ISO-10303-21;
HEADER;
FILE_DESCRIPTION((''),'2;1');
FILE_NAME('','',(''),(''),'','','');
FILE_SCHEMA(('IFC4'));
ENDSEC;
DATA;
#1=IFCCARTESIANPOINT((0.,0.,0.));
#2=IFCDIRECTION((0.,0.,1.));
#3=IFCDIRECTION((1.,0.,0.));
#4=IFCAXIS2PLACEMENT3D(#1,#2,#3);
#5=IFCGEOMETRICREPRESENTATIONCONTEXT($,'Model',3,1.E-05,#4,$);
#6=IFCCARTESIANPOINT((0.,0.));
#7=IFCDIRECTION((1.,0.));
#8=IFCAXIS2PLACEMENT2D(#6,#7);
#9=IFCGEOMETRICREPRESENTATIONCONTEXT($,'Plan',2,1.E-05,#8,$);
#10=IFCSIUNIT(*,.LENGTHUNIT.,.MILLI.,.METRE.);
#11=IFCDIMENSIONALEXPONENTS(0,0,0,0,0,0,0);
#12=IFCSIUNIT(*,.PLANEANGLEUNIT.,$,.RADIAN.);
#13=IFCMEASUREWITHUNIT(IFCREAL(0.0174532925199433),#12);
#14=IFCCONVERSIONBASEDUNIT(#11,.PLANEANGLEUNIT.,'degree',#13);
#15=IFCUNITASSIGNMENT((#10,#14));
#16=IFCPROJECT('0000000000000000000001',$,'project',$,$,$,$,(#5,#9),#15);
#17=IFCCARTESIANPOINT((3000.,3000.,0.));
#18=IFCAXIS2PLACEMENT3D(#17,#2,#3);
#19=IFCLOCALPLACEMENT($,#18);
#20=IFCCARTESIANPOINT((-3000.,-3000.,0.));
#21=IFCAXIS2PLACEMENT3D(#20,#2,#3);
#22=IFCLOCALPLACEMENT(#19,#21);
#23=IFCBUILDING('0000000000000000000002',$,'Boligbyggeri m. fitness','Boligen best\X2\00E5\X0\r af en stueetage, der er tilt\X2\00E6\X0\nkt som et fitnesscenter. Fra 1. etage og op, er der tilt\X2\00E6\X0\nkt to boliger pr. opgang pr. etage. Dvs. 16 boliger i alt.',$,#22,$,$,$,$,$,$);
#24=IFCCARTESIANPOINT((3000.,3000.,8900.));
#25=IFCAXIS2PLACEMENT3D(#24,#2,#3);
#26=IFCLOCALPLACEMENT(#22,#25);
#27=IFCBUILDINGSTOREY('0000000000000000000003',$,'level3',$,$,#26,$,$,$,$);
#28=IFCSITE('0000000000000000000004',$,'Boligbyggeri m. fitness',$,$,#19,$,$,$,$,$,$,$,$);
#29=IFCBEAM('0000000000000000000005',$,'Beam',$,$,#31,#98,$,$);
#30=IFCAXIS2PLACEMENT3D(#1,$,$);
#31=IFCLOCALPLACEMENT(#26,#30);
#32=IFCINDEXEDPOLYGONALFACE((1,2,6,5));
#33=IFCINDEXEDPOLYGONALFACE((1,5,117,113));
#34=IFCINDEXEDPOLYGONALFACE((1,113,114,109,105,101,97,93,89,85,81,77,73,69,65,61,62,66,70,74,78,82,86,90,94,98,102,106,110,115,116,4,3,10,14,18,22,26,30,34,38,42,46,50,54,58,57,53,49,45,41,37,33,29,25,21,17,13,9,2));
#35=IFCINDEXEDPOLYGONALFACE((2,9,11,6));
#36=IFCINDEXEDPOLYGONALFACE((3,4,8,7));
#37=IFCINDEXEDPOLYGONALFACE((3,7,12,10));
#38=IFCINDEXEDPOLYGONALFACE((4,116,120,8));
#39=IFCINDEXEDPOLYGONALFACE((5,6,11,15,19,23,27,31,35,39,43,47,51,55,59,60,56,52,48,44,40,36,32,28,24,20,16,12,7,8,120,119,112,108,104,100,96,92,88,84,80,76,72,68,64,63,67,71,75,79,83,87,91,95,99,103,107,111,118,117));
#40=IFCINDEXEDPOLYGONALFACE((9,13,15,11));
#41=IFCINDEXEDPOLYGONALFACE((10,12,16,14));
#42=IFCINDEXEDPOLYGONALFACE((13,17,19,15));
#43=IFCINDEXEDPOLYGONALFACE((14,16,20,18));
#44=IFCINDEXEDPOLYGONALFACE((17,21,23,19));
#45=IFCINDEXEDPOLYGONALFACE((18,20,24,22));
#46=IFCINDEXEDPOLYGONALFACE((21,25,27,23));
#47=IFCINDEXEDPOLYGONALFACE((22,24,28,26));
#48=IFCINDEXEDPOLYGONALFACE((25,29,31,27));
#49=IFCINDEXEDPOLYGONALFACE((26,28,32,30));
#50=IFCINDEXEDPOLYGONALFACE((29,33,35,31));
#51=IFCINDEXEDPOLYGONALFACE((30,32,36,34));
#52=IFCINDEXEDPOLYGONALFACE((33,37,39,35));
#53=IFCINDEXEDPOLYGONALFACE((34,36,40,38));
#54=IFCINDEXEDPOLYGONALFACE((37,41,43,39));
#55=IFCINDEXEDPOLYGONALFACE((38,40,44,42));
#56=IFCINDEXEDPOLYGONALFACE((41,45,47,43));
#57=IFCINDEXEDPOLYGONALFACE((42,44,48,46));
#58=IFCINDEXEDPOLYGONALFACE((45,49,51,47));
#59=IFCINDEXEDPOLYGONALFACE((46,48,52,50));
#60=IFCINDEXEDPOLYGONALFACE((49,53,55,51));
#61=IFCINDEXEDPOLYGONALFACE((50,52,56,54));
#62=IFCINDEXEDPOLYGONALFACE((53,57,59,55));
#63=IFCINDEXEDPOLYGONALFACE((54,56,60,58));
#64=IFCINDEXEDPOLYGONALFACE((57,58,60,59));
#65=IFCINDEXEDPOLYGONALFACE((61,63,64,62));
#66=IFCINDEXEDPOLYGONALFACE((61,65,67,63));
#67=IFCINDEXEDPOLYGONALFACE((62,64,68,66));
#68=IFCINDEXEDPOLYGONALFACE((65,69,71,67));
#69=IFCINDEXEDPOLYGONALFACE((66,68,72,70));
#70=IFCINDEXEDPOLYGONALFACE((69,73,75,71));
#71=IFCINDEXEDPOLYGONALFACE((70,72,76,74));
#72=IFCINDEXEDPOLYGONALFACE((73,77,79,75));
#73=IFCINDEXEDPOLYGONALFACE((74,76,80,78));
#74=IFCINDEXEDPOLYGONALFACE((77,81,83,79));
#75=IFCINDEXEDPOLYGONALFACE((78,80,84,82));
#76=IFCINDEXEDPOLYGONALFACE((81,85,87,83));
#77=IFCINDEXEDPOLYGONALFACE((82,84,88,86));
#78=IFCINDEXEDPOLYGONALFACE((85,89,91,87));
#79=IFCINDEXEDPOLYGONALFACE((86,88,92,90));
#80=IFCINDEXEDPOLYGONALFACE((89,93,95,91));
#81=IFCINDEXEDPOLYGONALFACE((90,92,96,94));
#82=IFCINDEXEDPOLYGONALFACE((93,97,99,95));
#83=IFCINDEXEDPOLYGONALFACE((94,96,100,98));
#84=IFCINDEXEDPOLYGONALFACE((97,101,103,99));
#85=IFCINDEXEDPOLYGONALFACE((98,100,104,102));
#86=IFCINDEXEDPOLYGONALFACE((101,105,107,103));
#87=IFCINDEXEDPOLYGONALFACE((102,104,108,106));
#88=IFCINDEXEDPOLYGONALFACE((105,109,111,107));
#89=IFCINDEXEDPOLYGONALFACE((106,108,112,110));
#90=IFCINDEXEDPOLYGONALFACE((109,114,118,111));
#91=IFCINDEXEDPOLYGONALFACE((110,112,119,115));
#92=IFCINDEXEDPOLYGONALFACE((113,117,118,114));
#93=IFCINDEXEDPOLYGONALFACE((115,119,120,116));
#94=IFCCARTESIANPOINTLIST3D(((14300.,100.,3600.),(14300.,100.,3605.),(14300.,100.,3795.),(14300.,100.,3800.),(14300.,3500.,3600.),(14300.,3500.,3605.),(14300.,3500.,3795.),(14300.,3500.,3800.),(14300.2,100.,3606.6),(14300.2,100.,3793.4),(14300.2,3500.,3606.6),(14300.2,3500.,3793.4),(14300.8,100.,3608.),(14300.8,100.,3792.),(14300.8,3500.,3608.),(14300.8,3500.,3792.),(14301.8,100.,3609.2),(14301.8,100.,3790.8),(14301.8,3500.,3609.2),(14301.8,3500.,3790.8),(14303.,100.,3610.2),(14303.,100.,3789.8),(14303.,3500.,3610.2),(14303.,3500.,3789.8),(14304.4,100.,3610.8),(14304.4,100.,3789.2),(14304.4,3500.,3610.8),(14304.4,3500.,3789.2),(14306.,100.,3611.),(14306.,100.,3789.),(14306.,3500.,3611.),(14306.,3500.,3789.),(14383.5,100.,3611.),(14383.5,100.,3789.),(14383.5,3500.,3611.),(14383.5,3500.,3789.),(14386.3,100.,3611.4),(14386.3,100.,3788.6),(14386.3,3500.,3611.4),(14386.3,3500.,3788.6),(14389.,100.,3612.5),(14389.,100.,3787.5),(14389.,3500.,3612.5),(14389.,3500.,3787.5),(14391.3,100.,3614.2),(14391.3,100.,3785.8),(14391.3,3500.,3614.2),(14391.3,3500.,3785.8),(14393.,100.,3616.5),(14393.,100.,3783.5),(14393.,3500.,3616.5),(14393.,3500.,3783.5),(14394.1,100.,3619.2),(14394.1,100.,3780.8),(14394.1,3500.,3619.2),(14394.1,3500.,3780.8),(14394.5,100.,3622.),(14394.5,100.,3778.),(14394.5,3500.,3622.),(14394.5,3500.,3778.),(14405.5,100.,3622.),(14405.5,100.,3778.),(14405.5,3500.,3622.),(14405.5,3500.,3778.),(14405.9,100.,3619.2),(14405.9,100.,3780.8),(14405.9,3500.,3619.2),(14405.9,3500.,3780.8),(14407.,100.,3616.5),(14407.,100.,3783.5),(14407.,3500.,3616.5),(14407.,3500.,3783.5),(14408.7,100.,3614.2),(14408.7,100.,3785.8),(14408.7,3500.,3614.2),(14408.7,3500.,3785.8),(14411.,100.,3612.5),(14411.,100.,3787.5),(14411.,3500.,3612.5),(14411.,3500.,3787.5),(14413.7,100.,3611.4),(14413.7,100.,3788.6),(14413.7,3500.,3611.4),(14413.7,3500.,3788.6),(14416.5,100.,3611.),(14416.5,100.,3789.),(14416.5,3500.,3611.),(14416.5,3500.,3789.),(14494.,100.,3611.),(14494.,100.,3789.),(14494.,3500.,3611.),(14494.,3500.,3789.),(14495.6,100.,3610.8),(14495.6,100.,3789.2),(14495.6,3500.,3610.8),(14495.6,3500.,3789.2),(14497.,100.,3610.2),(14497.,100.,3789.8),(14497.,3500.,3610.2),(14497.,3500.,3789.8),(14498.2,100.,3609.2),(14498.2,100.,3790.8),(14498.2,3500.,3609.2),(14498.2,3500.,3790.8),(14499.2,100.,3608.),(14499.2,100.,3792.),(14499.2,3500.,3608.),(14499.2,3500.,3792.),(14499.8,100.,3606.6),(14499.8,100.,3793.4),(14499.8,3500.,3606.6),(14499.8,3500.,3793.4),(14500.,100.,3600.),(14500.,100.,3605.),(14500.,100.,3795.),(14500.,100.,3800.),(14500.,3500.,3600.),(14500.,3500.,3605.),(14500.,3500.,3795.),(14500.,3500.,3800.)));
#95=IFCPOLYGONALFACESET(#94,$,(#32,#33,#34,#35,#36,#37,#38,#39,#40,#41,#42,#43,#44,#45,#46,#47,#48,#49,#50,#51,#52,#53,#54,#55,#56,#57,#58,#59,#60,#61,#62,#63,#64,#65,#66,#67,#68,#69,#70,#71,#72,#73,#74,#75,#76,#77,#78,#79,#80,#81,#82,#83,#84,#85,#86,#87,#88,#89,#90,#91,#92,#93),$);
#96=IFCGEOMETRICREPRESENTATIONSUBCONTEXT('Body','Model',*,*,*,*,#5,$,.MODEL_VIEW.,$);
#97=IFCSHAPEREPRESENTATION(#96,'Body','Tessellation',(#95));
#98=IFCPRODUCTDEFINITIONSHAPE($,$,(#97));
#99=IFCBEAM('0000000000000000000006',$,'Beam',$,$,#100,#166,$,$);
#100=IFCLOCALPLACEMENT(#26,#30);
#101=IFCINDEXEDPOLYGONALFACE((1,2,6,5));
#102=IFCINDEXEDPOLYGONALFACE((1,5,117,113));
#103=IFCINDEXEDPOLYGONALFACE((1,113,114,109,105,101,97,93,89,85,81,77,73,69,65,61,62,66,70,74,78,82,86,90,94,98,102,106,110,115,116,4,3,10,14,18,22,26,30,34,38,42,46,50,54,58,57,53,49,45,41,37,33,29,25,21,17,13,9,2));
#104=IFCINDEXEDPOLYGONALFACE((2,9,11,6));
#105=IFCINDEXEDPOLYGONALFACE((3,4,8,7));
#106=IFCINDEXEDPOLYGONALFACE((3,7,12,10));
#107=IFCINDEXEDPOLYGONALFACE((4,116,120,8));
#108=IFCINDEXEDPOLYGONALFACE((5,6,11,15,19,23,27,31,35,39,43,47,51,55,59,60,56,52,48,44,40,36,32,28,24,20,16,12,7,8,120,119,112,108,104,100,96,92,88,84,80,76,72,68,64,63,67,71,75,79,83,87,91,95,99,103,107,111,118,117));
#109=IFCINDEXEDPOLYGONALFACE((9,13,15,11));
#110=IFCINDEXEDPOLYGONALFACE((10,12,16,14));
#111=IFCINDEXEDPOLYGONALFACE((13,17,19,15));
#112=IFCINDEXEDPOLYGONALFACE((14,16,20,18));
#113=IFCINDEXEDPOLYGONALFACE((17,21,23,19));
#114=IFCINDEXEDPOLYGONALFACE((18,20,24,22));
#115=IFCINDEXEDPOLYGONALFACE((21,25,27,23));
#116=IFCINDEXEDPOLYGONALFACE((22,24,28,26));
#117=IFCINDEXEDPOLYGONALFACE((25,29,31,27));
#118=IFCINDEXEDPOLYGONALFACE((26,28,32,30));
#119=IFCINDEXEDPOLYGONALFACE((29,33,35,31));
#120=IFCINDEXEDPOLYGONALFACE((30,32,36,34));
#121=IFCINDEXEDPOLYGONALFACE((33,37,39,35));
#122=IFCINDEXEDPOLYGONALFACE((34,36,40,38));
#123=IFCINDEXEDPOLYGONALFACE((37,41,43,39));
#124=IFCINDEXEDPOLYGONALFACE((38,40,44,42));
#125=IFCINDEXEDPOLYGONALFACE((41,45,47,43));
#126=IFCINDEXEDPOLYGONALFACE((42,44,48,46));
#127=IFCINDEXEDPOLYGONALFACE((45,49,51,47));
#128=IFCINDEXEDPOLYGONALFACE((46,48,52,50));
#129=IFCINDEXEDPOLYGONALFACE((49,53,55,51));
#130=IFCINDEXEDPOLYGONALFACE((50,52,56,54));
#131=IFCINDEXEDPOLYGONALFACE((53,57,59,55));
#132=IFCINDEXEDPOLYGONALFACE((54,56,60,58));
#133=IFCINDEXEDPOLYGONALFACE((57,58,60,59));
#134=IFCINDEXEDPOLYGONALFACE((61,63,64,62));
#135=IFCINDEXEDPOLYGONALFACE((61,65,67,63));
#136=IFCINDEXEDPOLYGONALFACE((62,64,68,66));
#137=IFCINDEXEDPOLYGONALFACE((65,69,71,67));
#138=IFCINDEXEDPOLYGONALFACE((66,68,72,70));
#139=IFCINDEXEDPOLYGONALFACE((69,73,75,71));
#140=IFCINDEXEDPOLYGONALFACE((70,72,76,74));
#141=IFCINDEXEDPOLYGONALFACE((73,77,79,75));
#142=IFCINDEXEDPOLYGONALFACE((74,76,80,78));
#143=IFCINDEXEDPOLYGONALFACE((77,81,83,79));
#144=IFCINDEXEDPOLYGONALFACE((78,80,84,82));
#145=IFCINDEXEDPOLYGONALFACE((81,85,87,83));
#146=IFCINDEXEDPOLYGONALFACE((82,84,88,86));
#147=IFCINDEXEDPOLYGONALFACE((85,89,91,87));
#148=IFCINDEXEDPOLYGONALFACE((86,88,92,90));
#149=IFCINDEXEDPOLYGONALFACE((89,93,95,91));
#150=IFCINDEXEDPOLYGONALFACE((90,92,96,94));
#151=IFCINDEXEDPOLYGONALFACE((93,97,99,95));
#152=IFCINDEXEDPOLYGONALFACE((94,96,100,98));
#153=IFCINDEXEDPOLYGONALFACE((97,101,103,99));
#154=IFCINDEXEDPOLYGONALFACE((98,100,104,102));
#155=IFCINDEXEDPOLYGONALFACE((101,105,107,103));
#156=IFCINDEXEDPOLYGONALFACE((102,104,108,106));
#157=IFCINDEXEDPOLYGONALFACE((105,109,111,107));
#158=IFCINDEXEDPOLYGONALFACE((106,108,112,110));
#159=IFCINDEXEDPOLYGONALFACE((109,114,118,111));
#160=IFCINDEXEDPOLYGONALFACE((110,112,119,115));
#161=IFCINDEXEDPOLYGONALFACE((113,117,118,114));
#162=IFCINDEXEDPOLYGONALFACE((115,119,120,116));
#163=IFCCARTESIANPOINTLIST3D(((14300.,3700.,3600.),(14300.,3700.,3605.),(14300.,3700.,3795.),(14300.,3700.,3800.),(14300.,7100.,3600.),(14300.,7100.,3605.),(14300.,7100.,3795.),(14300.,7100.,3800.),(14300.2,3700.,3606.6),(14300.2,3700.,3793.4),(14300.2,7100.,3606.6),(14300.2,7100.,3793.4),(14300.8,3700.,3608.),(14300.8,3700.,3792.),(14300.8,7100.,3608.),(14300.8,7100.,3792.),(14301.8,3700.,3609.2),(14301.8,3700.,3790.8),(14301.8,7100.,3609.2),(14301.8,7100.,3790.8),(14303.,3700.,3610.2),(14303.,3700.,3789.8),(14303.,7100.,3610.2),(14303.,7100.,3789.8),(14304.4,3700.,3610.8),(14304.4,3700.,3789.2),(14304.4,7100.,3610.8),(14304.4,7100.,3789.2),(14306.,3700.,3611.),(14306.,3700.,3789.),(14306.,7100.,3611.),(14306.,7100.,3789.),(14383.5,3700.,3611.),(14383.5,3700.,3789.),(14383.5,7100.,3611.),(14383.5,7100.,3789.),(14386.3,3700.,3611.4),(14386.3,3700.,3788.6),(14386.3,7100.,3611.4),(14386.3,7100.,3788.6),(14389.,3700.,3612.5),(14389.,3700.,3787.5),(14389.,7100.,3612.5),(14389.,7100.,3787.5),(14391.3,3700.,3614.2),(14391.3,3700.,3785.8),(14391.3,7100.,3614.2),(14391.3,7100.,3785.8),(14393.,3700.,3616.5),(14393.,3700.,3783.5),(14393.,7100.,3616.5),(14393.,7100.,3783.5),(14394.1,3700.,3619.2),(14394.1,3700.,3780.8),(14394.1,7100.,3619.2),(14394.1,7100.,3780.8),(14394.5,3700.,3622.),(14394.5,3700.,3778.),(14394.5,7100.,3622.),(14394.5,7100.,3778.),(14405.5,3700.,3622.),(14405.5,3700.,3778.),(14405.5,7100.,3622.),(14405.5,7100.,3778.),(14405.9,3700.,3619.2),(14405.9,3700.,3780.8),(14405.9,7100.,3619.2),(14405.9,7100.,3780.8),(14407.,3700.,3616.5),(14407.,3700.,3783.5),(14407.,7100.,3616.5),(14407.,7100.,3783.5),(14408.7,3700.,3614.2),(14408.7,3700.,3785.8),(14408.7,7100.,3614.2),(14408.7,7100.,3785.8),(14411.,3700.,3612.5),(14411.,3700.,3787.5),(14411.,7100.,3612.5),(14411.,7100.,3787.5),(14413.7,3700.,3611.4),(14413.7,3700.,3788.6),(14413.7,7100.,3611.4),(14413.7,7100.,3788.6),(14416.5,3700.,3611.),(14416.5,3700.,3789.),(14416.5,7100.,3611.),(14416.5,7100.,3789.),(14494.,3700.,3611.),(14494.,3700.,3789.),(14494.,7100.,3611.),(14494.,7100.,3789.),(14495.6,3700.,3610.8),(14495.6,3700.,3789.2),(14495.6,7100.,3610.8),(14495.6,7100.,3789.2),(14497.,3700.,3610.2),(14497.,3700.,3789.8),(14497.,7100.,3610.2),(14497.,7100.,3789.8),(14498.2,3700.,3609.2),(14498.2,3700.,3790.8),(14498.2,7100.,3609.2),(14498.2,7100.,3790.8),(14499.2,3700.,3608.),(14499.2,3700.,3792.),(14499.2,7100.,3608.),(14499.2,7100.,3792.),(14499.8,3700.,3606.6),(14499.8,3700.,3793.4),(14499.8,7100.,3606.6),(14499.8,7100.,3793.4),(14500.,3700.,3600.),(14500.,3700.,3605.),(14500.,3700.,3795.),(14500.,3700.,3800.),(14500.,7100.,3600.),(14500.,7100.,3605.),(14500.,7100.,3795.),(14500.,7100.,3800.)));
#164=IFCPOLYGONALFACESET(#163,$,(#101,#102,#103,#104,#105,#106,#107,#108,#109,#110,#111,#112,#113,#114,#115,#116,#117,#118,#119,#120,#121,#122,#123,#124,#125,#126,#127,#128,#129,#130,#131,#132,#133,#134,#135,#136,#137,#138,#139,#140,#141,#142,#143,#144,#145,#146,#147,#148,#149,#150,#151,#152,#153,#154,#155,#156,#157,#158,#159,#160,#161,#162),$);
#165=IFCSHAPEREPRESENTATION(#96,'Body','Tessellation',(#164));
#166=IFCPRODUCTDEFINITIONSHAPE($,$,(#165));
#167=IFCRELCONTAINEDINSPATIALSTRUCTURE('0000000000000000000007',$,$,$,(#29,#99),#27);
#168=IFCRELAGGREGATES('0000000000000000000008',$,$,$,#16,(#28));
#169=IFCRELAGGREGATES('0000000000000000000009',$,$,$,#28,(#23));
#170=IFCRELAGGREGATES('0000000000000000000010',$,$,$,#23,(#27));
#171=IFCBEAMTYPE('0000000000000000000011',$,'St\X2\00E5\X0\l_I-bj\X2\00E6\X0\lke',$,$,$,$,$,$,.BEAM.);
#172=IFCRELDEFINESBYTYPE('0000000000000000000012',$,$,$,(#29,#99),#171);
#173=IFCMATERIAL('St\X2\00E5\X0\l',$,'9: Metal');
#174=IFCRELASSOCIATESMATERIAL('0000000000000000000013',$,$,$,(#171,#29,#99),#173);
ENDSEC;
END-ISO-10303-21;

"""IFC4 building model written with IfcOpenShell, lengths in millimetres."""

from ifc_helpers import new_model, entity, si_unit, converted_unit, frame, origin_with_axes, origin_2d_with_axis, place, context, subcontext, project, spatial, i_section, extrude, material, material_profile, profile_set, profile_usage, type_object, element, save


model = new_model("IFC4")

# Units and contexts
model_context = context("Model", 3, precision=1e-05, world=origin_with_axes())
plan_context = context("Plan", 2, precision=1e-05, world=origin_2d_with_axis())
body_context = subcontext(model_context, "Body", "Model", "MODEL_VIEW")
ifc_project = project(units=[si_unit("LENGTHUNIT", "METRE", prefix="MILLI"), converted_unit("PLANEANGLEUNIT", "degree", entity("IfcReal", 0.0174532925199433), si_unit("PLANEANGLEUNIT", "RADIAN"), dimensions=[0, 0, 0, 0, 0, 0, 0])], contexts=[model_context, plan_context])

# Site, building, storey
site_placement = place(None, frame((3000.0, 3000.0, 0.0), z_axis=(0.0, 0.0, 1.0), x_axis=(1.0, 0.0, 0.0)))
site = spatial("IfcSite", under=ifc_project, at=site_placement, Name="Boligbyggeri m. fitness")
building_placement = place(site_placement, frame((-3000.0, -3000.0, 0.0), z_axis=(0.0, 0.0, 1.0), x_axis=(1.0, 0.0, 0.0)))
building = spatial("IfcBuilding", under=site, at=building_placement, Name="Boligbyggeri m. fitness", Description="Boligen består af en stueetage, der er tiltænkt som et fitnesscenter. Fra 1. etage og op, er der tiltænkt to boliger pr. opgang pr. etage. Dvs. 16 boliger i alt.")
storey_placement = place(building_placement, frame((3000.0, 3000.0, 8900.0), z_axis=(0.0, 0.0, 1.0), x_axis=(1.0, 0.0, 0.0)))
storey = spatial("IfcBuildingStorey", under=building, at=storey_placement, Name="level3")

# Beams
ifc_material_1 = material(Name="Stål", Category="9: Metal")
ifc_material_profile_1 = material_profile(ifc_material_1, i_section(OverallWidth=200.0, OverallDepth=200.0, WebThickness=11.0, FlangeThickness=11.0, FilletRadius=11.0, FlangeEdgeRadius=6.0), Name="Stål", Category="9: Metal")
ifc_profile_set_1 = profile_set([ifc_material_profile_1], Name="NY_I-Profil")
beam_type = type_object("IfcBeamType", Name="Stål_I-bjælke", PredefinedType="BEAM", material=ifc_profile_set_1)
ifc_profile_usage_1 = profile_usage(ifc_profile_set_1, cardinal=9)
beam_1_placement = place(storey_placement, frame((14500.0, 100.0, 3800.0), z_axis=(0.0, 1.0, 0.0), x_axis=(-1.0, 0.0, 0.0)))
element("IfcBeam", 1, at=beam_1_placement, inside=storey, type_object=beam_type, material=ifc_profile_usage_1, Name="Beam", context=body_context, shape_type="SweptSolid", body=[
    extrude(i_section(OverallWidth=200.0, OverallDepth=200.0, WebThickness=11.0, FlangeThickness=11.0, FilletRadius=11.0, FlangeEdgeRadius=6.0), frame((100.0, -100.0, 0.0), z_axis=(0.0, 0.0, 1.0), x_axis=(1.0, 0.0, 0.0)), (0.0, 0.0, 1.0), 3400.0),
])
ifc_profile_usage_2 = profile_usage(ifc_profile_set_1, cardinal=9)
beam_2_placement = place(storey_placement, frame((14500.0, 3700.0, 3800.0), z_axis=(0.0, 1.0, 0.0), x_axis=(-1.0, 0.0, 0.0)))
element("IfcBeam", 2, at=beam_2_placement, inside=storey, type_object=beam_type, material=ifc_profile_usage_2, Name="Beam", context=body_context, shape_type="SweptSolid", body=[
    extrude(i_section(OverallWidth=200.0, OverallDepth=200.0, WebThickness=11.0, FlangeThickness=11.0, FilletRadius=11.0, FlangeEdgeRadius=6.0), frame((100.0, -100.0, 0.0), z_axis=(0.0, 0.0, 1.0), x_axis=(1.0, 0.0, 0.0)), (0.0, 0.0, 1.0), 3400.0),
])

save(model, "model.ifc")
